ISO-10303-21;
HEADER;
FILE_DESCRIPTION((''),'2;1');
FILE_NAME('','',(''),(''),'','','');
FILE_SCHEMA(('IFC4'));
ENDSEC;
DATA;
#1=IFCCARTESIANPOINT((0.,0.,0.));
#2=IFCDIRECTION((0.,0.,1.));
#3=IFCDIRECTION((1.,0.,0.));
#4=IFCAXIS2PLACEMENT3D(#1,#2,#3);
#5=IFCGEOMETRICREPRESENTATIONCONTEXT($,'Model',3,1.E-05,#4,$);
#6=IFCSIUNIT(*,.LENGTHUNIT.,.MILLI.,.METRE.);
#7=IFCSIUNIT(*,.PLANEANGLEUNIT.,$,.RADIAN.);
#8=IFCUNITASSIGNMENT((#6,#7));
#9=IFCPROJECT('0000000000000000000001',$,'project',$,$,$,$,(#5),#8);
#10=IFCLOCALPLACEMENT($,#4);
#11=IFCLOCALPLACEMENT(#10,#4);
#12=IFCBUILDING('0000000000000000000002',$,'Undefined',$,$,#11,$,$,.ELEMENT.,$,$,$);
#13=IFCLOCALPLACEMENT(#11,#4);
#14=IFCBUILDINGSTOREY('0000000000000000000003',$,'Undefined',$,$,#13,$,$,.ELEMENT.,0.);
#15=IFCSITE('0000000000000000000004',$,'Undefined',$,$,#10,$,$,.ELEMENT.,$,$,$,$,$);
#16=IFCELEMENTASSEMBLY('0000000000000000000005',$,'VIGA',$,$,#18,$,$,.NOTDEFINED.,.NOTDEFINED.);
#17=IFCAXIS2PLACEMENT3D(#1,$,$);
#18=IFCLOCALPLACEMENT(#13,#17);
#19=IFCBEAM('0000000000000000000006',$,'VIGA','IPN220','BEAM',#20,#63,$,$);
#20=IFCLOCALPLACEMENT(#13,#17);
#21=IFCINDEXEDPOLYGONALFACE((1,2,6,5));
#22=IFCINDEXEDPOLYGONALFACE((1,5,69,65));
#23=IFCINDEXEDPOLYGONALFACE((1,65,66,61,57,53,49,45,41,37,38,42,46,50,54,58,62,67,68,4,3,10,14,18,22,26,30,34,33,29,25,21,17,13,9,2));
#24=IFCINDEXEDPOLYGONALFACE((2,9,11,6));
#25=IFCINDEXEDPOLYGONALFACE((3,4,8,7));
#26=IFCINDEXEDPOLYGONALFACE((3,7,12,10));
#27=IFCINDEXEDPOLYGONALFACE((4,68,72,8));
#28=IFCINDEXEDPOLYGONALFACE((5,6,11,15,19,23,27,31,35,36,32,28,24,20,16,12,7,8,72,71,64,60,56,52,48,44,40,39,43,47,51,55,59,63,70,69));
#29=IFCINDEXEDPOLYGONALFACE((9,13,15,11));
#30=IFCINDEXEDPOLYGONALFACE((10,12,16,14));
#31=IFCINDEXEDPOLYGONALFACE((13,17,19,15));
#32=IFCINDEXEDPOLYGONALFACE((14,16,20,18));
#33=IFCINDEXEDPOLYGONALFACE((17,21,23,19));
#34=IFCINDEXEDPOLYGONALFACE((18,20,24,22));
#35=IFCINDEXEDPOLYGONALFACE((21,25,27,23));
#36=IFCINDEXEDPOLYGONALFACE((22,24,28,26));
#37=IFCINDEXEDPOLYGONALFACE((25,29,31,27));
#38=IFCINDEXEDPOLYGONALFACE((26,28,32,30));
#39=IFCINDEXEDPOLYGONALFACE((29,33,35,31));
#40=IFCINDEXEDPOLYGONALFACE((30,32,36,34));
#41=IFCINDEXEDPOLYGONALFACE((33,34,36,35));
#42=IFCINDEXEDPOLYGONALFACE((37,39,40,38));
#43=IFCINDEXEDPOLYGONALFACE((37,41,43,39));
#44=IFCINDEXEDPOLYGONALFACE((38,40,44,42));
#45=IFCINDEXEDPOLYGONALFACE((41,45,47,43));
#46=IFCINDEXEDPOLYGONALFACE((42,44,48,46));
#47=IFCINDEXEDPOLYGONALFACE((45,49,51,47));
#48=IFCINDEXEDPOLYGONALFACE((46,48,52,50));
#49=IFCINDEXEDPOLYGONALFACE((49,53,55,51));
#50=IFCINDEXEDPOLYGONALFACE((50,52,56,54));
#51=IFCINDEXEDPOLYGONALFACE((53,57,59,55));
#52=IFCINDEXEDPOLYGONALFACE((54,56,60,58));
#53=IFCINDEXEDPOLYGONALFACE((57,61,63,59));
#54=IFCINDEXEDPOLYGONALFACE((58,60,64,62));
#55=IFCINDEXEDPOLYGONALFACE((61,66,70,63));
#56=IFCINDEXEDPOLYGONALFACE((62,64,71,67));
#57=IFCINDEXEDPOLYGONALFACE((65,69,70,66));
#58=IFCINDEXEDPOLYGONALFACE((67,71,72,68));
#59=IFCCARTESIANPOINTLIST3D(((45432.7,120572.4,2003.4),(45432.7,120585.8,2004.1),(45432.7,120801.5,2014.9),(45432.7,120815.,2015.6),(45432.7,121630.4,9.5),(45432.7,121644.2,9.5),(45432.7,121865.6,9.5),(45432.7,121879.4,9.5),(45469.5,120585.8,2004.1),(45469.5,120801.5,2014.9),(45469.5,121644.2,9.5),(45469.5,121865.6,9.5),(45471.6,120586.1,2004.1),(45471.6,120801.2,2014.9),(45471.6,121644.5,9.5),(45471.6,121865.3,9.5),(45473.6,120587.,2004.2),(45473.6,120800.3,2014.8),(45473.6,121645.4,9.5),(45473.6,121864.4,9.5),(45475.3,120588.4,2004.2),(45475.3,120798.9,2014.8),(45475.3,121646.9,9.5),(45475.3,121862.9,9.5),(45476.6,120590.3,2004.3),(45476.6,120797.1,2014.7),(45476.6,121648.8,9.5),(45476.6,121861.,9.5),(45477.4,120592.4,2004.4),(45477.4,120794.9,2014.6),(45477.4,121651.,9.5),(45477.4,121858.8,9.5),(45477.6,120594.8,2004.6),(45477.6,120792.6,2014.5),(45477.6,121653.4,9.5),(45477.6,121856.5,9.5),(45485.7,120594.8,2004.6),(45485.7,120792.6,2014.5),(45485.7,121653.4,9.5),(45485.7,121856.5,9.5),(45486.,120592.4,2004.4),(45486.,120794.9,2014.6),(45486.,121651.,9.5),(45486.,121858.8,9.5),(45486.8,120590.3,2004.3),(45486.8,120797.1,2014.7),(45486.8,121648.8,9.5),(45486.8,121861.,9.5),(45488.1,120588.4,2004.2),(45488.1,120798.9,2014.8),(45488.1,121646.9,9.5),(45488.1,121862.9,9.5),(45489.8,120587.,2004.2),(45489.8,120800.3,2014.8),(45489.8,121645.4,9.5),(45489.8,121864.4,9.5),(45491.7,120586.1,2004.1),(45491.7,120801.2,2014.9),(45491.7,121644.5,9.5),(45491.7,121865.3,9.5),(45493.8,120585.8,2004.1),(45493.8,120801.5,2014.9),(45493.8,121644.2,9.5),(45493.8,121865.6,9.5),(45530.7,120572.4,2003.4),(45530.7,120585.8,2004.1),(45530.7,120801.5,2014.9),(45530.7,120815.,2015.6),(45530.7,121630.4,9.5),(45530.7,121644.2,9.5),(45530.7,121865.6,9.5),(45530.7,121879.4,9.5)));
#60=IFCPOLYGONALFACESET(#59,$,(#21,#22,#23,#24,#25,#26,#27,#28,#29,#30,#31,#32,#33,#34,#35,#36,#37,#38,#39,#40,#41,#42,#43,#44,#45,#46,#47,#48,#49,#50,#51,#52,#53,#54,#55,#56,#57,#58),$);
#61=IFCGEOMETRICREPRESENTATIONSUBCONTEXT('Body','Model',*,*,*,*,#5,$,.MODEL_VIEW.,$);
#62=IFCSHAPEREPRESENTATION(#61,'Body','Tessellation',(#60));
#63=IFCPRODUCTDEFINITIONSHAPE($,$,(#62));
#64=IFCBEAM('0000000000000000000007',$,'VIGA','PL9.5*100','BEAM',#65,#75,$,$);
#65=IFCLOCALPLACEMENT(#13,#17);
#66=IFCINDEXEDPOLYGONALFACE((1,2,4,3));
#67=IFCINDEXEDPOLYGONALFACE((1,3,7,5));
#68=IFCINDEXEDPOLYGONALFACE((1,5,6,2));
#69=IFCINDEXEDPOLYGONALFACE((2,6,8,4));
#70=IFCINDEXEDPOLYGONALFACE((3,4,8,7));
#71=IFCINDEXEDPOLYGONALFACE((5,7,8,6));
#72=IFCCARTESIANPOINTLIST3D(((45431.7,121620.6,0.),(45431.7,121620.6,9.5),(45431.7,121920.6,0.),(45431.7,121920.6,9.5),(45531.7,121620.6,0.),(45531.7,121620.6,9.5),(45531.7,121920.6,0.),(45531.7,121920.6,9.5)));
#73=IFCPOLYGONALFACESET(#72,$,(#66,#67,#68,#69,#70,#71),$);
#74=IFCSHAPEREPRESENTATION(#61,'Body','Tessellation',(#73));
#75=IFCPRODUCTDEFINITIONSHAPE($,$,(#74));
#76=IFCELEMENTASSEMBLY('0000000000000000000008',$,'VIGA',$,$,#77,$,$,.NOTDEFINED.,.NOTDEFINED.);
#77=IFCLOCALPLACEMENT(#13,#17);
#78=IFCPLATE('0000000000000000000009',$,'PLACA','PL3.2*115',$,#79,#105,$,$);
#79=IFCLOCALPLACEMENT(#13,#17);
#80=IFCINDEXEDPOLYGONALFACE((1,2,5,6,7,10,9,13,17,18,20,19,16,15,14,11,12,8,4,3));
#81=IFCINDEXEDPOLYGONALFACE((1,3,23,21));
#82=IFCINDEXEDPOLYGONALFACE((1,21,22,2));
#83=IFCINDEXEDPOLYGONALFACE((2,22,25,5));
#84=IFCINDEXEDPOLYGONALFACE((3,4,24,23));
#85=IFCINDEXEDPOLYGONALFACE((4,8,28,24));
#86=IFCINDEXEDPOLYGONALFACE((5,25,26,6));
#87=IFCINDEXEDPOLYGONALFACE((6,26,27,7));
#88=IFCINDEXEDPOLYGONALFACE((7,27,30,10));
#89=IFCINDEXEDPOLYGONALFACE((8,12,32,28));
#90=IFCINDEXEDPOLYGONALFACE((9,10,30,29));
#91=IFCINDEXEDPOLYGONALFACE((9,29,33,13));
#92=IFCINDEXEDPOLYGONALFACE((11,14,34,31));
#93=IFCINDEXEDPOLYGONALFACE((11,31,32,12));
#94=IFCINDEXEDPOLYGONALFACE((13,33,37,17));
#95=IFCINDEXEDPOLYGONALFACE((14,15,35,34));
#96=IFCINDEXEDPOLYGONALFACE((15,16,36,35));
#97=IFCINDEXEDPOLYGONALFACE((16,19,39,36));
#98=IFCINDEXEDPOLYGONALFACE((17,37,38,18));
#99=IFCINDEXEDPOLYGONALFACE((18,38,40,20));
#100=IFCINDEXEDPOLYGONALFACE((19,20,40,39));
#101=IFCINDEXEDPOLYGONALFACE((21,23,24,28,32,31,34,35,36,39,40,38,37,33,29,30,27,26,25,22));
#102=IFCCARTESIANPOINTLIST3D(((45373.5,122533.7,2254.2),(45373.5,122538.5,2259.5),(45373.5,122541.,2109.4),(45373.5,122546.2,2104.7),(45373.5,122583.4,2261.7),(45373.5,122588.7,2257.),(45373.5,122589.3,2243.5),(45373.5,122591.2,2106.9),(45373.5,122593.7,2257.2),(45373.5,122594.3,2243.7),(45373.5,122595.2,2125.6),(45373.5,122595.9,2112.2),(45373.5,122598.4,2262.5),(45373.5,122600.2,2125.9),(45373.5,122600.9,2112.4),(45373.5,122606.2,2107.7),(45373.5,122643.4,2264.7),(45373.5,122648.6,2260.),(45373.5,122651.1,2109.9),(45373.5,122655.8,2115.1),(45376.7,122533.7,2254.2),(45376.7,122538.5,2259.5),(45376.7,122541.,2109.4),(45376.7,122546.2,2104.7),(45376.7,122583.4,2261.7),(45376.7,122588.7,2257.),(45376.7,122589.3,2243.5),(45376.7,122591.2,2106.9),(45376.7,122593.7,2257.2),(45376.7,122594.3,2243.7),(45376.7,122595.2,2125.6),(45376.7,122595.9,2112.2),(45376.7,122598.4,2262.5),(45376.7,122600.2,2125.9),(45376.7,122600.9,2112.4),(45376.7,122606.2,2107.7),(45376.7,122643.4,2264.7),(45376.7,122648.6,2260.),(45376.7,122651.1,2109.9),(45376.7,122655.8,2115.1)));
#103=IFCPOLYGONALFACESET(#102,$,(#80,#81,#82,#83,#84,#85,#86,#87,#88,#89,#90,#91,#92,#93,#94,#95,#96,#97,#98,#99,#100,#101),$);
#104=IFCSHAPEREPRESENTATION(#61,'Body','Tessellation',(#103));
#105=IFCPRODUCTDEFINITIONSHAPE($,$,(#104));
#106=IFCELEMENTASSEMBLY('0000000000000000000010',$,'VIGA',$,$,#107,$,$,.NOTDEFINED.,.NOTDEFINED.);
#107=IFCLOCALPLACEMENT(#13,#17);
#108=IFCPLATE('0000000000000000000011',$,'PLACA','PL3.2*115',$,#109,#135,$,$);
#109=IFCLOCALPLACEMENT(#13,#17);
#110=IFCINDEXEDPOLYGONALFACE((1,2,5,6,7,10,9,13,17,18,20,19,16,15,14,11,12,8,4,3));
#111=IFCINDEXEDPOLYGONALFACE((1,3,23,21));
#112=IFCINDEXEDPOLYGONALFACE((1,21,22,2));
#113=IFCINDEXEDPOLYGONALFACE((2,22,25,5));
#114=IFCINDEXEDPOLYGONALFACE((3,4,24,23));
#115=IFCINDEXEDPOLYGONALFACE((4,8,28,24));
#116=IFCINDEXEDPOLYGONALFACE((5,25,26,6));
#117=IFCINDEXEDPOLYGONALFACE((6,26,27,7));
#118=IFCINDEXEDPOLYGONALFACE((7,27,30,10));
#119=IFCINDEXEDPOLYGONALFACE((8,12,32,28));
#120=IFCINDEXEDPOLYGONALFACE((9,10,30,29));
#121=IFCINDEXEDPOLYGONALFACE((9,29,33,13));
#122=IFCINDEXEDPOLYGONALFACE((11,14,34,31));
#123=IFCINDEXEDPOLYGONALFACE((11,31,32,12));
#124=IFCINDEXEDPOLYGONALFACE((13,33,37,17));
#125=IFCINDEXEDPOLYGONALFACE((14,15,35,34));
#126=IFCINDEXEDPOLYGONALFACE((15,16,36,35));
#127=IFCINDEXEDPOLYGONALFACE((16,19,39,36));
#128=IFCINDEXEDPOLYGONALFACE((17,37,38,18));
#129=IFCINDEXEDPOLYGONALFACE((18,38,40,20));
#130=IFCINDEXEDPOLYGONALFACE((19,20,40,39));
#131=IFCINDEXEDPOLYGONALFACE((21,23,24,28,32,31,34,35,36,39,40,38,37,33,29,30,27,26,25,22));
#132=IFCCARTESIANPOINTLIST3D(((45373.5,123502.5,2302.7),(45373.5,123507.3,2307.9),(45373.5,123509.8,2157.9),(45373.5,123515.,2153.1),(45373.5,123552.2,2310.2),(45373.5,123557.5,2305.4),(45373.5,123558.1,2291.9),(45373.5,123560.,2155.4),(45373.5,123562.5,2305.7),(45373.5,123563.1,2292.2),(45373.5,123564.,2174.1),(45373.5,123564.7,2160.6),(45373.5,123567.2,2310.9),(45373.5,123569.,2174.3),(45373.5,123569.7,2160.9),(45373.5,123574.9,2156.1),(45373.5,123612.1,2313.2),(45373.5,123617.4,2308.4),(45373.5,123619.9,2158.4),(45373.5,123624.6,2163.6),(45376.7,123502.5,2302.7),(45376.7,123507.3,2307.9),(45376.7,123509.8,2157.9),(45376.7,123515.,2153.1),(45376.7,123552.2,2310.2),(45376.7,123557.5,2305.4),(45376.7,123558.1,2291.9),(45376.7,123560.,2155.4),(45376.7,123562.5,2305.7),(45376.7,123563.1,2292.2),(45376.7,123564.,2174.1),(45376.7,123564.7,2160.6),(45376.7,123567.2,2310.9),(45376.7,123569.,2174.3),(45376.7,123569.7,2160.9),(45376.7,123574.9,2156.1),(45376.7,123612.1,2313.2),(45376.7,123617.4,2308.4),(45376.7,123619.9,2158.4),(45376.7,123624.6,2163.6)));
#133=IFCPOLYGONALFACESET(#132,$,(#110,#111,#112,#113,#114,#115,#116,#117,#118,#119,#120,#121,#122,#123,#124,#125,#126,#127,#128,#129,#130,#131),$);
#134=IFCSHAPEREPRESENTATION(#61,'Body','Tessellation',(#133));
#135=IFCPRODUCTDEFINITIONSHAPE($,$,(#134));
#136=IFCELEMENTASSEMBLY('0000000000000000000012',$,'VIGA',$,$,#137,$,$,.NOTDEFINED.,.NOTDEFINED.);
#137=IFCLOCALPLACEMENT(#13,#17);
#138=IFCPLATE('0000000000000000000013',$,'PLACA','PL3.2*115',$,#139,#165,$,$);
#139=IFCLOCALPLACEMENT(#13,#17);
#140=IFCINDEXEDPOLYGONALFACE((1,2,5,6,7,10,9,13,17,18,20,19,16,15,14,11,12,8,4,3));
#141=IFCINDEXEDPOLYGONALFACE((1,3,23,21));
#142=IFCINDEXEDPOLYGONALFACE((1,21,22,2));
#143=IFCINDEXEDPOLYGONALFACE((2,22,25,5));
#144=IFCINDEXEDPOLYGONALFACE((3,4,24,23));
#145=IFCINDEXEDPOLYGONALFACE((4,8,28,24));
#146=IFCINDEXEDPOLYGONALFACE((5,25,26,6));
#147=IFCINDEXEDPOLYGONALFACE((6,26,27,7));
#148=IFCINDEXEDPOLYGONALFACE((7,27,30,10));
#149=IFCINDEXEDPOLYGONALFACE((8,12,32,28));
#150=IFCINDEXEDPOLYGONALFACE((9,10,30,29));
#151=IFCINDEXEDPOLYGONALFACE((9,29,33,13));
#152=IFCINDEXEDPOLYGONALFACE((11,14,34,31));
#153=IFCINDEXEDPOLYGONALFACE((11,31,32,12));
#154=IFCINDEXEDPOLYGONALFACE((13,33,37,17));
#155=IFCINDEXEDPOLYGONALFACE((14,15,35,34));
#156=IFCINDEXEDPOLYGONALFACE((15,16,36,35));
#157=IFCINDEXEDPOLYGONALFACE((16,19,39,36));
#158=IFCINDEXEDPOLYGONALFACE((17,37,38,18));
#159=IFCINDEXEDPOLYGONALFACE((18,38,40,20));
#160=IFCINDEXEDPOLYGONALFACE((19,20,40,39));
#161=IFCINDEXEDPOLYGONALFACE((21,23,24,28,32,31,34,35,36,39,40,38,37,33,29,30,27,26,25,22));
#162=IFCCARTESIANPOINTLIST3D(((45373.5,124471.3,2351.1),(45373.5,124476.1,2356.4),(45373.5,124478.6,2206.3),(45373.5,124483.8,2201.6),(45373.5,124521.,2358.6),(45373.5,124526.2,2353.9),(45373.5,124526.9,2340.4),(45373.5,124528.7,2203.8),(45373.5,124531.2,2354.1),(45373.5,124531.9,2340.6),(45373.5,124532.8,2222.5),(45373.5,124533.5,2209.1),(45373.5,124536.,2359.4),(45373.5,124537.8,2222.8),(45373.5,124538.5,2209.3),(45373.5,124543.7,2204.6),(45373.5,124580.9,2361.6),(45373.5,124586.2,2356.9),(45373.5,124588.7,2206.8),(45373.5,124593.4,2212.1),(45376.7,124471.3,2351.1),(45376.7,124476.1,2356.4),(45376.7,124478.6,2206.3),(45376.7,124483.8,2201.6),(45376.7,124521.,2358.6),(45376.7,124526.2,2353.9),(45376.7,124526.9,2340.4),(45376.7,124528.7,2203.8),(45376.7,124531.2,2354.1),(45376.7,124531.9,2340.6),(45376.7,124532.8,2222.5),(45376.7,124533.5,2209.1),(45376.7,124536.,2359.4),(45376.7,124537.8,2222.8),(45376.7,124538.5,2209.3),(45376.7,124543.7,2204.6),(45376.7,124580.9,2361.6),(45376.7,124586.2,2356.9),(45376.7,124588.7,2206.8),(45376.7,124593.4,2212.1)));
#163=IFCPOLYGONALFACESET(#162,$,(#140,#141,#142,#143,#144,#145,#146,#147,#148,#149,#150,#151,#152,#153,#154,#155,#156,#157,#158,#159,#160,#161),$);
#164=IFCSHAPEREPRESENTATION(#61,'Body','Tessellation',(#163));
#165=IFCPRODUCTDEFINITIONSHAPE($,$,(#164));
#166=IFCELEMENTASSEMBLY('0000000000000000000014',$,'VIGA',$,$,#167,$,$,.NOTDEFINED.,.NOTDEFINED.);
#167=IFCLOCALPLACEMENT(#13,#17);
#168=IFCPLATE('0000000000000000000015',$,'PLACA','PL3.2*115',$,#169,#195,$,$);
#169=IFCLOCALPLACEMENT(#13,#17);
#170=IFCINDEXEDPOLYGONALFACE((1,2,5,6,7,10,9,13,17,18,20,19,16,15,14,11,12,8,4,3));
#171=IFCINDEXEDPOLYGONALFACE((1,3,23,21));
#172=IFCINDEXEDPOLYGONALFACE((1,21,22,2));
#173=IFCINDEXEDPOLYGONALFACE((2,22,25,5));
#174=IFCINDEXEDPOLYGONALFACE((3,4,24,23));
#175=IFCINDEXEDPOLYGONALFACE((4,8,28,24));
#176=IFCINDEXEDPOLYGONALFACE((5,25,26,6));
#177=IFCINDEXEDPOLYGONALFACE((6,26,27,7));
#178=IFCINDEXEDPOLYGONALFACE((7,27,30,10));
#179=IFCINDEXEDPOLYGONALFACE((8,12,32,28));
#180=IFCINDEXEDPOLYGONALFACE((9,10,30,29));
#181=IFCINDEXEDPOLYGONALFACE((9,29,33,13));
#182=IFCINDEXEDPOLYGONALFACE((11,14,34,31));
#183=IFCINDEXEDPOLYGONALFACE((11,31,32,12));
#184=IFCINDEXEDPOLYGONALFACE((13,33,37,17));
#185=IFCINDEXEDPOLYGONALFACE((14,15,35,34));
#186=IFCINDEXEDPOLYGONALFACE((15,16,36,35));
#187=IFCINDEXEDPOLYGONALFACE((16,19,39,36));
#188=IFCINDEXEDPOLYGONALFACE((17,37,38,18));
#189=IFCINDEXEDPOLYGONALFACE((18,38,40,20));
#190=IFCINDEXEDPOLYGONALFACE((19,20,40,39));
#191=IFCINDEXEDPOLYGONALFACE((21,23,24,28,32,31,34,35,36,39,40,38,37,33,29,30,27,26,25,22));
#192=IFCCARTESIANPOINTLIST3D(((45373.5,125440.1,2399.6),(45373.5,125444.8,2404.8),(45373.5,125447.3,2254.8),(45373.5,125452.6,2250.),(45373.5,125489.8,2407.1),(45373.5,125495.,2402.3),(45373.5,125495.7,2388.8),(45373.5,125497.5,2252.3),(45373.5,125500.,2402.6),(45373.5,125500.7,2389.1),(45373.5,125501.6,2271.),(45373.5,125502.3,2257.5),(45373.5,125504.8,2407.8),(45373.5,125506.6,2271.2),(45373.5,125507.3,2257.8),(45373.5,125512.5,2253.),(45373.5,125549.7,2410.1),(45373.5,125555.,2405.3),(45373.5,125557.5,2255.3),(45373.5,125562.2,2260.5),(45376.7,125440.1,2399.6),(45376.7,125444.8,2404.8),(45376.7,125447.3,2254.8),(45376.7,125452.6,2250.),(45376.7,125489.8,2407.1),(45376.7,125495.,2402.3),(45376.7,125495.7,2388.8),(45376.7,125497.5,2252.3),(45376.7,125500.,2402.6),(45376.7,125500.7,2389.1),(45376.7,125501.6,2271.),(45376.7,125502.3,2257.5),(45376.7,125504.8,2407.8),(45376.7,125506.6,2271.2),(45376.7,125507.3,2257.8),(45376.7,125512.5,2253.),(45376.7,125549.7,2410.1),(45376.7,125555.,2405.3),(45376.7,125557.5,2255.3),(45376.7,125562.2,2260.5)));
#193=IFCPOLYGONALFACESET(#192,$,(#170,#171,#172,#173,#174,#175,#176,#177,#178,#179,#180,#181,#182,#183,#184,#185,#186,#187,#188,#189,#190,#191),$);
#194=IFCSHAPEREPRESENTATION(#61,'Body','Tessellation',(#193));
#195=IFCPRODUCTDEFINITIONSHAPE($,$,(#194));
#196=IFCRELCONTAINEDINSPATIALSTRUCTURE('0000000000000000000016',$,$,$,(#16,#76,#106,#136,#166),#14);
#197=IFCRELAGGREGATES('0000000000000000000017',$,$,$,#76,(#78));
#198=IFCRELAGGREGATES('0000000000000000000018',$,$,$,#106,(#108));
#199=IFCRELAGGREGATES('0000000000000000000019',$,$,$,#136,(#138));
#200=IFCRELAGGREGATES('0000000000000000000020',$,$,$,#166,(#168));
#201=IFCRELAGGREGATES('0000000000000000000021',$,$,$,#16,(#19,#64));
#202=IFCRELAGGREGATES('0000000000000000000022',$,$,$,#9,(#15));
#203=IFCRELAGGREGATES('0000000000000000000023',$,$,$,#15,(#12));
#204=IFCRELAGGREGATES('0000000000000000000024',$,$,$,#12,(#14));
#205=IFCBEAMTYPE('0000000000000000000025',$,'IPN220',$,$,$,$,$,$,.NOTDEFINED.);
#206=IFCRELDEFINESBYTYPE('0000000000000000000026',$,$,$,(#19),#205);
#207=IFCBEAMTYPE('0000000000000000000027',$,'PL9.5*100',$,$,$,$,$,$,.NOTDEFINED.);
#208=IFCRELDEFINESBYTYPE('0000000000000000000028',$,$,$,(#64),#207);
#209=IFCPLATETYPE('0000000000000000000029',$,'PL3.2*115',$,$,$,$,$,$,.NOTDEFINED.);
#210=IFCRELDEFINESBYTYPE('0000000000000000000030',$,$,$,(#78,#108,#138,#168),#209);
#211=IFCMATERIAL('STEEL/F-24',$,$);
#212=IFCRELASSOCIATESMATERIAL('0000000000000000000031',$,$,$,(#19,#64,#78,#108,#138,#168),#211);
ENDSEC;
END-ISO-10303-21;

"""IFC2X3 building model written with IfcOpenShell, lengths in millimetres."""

from ifc_helpers import new_model, si_unit, frame, origin_with_axes, origin_2d_with_axis, place, context, subcontext, project, spatial, polyline, rectangle, i_section, outline, extrude, clip, halfspace, material, type_object, element, aggregate, save


model = new_model("IFC2X3")

# Units and contexts
model_context = context("Model", 3, precision=1e-05, world=origin_with_axes())
body_context = subcontext(model_context, "Body", "Model", "MODEL_VIEW")
ifc_project = project(units=[si_unit("LENGTHUNIT", "METRE", prefix="MILLI"), si_unit("PLANEANGLEUNIT", "RADIAN")], contexts=[model_context])

# Site, building, storey
site_placement = place(None, origin_with_axes())
site = spatial("IfcSite", under=ifc_project, at=site_placement, Name="Undefined", CompositionType="ELEMENT")
building_placement = place(site_placement, origin_with_axes())
building = spatial("IfcBuilding", under=site, at=building_placement, Name="Undefined", CompositionType="ELEMENT")
storey_placement = place(building_placement, origin_with_axes())
storey = spatial("IfcBuildingStorey", under=building, at=storey_placement, Name="Undefined", CompositionType="ELEMENT", Elevation=0.0)

# Element assembly
assembly_1_placement = place(storey_placement, origin_with_axes())
assembly_1 = element("IfcElementAssembly", 1, at=assembly_1_placement, inside=storey, Name="VIGA", AssemblyPlace="NOTDEFINED", PredefinedType="NOTDEFINED")
ifc_material_1 = material(Name="STEEL/F-24")

# Beams
beam_type_1 = type_object("IfcBeamType", Name="IPN220", PredefinedType="NOTDEFINED")
beam_1_placement = place(assembly_1_placement, frame((45481.7, 121754.9, 9.5), z_axis=(0.0, -0.88335, -0.468715), x_axis=(0.0, -0.468715, 0.88335)))
beam_1 = element("IfcBeam", 2, at=beam_1_placement, type_object=beam_type_1, material=ifc_material_1, Name="VIGA", Description="IPN220", ObjectType="BEAM", context=body_context, shape_type="Clipping", body=[
    clip(clip(extrude(i_section(OverallWidth=98.0, OverallDepth=220.0, WebThickness=8.1, FlangeThickness=12.2, FilletRadius=8.1, at=origin_2d_with_axis()), frame((2385.9, 0.0, 0.0), z_axis=(-1.0, 0.0, 0.0), x_axis=(0.0, -1.0, 0.0)), (0.0, 0.0, 1.0), 2507.7), halfspace(frame((2264.1, 0.0, 0.0), z_axis=(-0.905659, 0.0, 0.424006), x_axis=(0.0, 1.0, 0.0)), True)), halfspace(frame((0.0, 0.0, 0.0), z_axis=(-0.88335, 0.0, 0.468715), x_axis=(0.0, -1.0, 0.0)), False)),
])
beam_type_2 = type_object("IfcBeamType", Name="PL9.5*100", PredefinedType="NOTDEFINED")
beam_2_placement = place(assembly_1_placement, frame((45481.7, 121620.6, 4.7), z_axis=(1.0, 0.0, 0.0), x_axis=(0.0, 1.0, 0.0)))
beam_2 = element("IfcBeam", 3, at=beam_2_placement, type_object=beam_type_2, material=ifc_material_1, Name="VIGA", Description="PL9.5*100", ObjectType="BEAM", context=body_context, shape_type="SweptSolid", body=[
    extrude(rectangle(XDim=9.5, YDim=100.0, at=origin_2d_with_axis()), frame((300.0, 0.0, 0.0), z_axis=(-1.0, 0.0, 0.0), x_axis=(0.0, -1.0, 0.0)), (0.0, 0.0, 1.0), 300.0),
])

# Element assemblies, plates
assembly_2_placement = place(storey_placement, origin_with_axes())
assembly_2 = element("IfcElementAssembly", 4, at=assembly_2_placement, inside=storey, Name="VIGA", AssemblyPlace="NOTDEFINED", PredefinedType="NOTDEFINED")
plate_type_1 = type_object("IfcPlateType", Name="PL3.2*115", PredefinedType="NOTDEFINED")
plate_1_placement = place(assembly_2_placement, frame((45375.1, 122533.5, 2259.2), z_axis=(-1.0, 0.0, 0.0), x_axis=(0.0, 0.998752, 0.04995)))
plate_1 = element("IfcPlate", 5, at=plate_1_placement, type_object=plate_type_1, material=ifc_material_1, Name="PLACA", Description="PL3.2*115", context=body_context, shape_type="SweptSolid", body=[
    extrude(outline(polyline([(0.0, 5.0), (5.0, 0.0), (50.0, 0.0), (55.0, 5.0), (55.0, 18.5), (60.0, 18.5), (60.0, 5.0), (65.0, 0.0), (110.0, 0.0), (115.0, 5.0), (115.0, 150.0), (110.0, 155.0), (65.0, 155.0), (60.0, 150.0), (60.0, 136.5), (55.0, 136.5), (55.0, 150.0), (50.0, 155.0), (5.0, 155.0), (0.0, 150.0), (0.0, 5.0)])), frame((0.0, 0.0, -1.6), z_axis=(0.0, 0.0, 1.0), x_axis=(1.0, 0.0, 0.0)), (0.0, 0.0, 1.0), 3.2),
])
assembly_3_placement = place(storey_placement, origin_with_axes())
assembly_3 = element("IfcElementAssembly", 6, at=assembly_3_placement, inside=storey, Name="VIGA", AssemblyPlace="NOTDEFINED", PredefinedType="NOTDEFINED")
plate_2_placement = place(assembly_3_placement, frame((45375.1, 123502.3, 2307.7), z_axis=(-1.0, 0.0, 0.0), x_axis=(0.0, 0.998752, 0.04995)))
plate_2 = element("IfcPlate", 7, at=plate_2_placement, type_object=plate_type_1, material=ifc_material_1, Name="PLACA", Description="PL3.2*115", context=body_context, shape_type="SweptSolid", body=[
    extrude(outline(polyline([(0.0, 5.0), (5.0, 0.0), (50.0, 0.0), (55.0, 5.0), (55.0, 18.5), (60.0, 18.5), (60.0, 5.0), (65.0, 0.0), (110.0, 0.0), (115.0, 5.0), (115.0, 150.0), (110.0, 155.0), (65.0, 155.0), (60.0, 150.0), (60.0, 136.5), (55.0, 136.5), (55.0, 150.0), (50.0, 155.0), (5.0, 155.0), (0.0, 150.0), (0.0, 5.0)])), frame((0.0, 0.0, -1.6), z_axis=(0.0, 0.0, 1.0), x_axis=(1.0, 0.0, 0.0)), (0.0, 0.0, 1.0), 3.2),
])
assembly_4_placement = place(storey_placement, origin_with_axes())
assembly_4 = element("IfcElementAssembly", 8, at=assembly_4_placement, inside=storey, Name="VIGA", AssemblyPlace="NOTDEFINED", PredefinedType="NOTDEFINED")
plate_3_placement = place(assembly_4_placement, frame((45375.1, 124471.1, 2356.1), z_axis=(-1.0, 0.0, 0.0), x_axis=(0.0, 0.998752, 0.04995)))
plate_3 = element("IfcPlate", 9, at=plate_3_placement, type_object=plate_type_1, material=ifc_material_1, Name="PLACA", Description="PL3.2*115", context=body_context, shape_type="SweptSolid", body=[
    extrude(outline(polyline([(0.0, 5.0), (5.0, 0.0), (50.0, 0.0), (55.0, 5.0), (55.0, 18.5), (60.0, 18.5), (60.0, 5.0), (65.0, 0.0), (110.0, 0.0), (115.0, 5.0), (115.0, 150.0), (110.0, 155.0), (65.0, 155.0), (60.0, 150.0), (60.0, 136.5), (55.0, 136.5), (55.0, 150.0), (50.0, 155.0), (5.0, 155.0), (0.0, 150.0), (0.0, 5.0)])), frame((0.0, 0.0, -1.6), z_axis=(0.0, 0.0, 1.0), x_axis=(1.0, 0.0, 0.0)), (0.0, 0.0, 1.0), 3.2),
])
assembly_5_placement = place(storey_placement, origin_with_axes())
assembly_5 = element("IfcElementAssembly", 10, at=assembly_5_placement, inside=storey, Name="VIGA", AssemblyPlace="NOTDEFINED", PredefinedType="NOTDEFINED")
plate_4_placement = place(assembly_5_placement, frame((45375.1, 125439.9, 2404.6), z_axis=(-1.0, 0.0, 0.0), x_axis=(0.0, 0.998752, 0.04995)))
plate_4 = element("IfcPlate", 11, at=plate_4_placement, type_object=plate_type_1, material=ifc_material_1, Name="PLACA", Description="PL3.2*115", context=body_context, shape_type="SweptSolid", body=[
    extrude(outline(polyline([(0.0, 5.0), (5.0, 0.0), (50.0, 0.0), (55.0, 5.0), (55.0, 18.5), (60.0, 18.5), (60.0, 5.0), (65.0, 0.0), (110.0, 0.0), (115.0, 5.0), (115.0, 150.0), (110.0, 155.0), (65.0, 155.0), (60.0, 150.0), (60.0, 136.5), (55.0, 136.5), (55.0, 150.0), (50.0, 155.0), (5.0, 155.0), (0.0, 150.0), (0.0, 5.0)])), frame((0.0, 0.0, -1.6), z_axis=(0.0, 0.0, 1.0), x_axis=(1.0, 0.0, 0.0)), (0.0, 0.0, 1.0), 3.2),
])

aggregate(assembly_2, [plate_1])
aggregate(assembly_3, [plate_2])
aggregate(assembly_4, [plate_3])
aggregate(assembly_5, [plate_4])
aggregate(assembly_1, [beam_1, beam_2])

save(model, "model.ifc")
